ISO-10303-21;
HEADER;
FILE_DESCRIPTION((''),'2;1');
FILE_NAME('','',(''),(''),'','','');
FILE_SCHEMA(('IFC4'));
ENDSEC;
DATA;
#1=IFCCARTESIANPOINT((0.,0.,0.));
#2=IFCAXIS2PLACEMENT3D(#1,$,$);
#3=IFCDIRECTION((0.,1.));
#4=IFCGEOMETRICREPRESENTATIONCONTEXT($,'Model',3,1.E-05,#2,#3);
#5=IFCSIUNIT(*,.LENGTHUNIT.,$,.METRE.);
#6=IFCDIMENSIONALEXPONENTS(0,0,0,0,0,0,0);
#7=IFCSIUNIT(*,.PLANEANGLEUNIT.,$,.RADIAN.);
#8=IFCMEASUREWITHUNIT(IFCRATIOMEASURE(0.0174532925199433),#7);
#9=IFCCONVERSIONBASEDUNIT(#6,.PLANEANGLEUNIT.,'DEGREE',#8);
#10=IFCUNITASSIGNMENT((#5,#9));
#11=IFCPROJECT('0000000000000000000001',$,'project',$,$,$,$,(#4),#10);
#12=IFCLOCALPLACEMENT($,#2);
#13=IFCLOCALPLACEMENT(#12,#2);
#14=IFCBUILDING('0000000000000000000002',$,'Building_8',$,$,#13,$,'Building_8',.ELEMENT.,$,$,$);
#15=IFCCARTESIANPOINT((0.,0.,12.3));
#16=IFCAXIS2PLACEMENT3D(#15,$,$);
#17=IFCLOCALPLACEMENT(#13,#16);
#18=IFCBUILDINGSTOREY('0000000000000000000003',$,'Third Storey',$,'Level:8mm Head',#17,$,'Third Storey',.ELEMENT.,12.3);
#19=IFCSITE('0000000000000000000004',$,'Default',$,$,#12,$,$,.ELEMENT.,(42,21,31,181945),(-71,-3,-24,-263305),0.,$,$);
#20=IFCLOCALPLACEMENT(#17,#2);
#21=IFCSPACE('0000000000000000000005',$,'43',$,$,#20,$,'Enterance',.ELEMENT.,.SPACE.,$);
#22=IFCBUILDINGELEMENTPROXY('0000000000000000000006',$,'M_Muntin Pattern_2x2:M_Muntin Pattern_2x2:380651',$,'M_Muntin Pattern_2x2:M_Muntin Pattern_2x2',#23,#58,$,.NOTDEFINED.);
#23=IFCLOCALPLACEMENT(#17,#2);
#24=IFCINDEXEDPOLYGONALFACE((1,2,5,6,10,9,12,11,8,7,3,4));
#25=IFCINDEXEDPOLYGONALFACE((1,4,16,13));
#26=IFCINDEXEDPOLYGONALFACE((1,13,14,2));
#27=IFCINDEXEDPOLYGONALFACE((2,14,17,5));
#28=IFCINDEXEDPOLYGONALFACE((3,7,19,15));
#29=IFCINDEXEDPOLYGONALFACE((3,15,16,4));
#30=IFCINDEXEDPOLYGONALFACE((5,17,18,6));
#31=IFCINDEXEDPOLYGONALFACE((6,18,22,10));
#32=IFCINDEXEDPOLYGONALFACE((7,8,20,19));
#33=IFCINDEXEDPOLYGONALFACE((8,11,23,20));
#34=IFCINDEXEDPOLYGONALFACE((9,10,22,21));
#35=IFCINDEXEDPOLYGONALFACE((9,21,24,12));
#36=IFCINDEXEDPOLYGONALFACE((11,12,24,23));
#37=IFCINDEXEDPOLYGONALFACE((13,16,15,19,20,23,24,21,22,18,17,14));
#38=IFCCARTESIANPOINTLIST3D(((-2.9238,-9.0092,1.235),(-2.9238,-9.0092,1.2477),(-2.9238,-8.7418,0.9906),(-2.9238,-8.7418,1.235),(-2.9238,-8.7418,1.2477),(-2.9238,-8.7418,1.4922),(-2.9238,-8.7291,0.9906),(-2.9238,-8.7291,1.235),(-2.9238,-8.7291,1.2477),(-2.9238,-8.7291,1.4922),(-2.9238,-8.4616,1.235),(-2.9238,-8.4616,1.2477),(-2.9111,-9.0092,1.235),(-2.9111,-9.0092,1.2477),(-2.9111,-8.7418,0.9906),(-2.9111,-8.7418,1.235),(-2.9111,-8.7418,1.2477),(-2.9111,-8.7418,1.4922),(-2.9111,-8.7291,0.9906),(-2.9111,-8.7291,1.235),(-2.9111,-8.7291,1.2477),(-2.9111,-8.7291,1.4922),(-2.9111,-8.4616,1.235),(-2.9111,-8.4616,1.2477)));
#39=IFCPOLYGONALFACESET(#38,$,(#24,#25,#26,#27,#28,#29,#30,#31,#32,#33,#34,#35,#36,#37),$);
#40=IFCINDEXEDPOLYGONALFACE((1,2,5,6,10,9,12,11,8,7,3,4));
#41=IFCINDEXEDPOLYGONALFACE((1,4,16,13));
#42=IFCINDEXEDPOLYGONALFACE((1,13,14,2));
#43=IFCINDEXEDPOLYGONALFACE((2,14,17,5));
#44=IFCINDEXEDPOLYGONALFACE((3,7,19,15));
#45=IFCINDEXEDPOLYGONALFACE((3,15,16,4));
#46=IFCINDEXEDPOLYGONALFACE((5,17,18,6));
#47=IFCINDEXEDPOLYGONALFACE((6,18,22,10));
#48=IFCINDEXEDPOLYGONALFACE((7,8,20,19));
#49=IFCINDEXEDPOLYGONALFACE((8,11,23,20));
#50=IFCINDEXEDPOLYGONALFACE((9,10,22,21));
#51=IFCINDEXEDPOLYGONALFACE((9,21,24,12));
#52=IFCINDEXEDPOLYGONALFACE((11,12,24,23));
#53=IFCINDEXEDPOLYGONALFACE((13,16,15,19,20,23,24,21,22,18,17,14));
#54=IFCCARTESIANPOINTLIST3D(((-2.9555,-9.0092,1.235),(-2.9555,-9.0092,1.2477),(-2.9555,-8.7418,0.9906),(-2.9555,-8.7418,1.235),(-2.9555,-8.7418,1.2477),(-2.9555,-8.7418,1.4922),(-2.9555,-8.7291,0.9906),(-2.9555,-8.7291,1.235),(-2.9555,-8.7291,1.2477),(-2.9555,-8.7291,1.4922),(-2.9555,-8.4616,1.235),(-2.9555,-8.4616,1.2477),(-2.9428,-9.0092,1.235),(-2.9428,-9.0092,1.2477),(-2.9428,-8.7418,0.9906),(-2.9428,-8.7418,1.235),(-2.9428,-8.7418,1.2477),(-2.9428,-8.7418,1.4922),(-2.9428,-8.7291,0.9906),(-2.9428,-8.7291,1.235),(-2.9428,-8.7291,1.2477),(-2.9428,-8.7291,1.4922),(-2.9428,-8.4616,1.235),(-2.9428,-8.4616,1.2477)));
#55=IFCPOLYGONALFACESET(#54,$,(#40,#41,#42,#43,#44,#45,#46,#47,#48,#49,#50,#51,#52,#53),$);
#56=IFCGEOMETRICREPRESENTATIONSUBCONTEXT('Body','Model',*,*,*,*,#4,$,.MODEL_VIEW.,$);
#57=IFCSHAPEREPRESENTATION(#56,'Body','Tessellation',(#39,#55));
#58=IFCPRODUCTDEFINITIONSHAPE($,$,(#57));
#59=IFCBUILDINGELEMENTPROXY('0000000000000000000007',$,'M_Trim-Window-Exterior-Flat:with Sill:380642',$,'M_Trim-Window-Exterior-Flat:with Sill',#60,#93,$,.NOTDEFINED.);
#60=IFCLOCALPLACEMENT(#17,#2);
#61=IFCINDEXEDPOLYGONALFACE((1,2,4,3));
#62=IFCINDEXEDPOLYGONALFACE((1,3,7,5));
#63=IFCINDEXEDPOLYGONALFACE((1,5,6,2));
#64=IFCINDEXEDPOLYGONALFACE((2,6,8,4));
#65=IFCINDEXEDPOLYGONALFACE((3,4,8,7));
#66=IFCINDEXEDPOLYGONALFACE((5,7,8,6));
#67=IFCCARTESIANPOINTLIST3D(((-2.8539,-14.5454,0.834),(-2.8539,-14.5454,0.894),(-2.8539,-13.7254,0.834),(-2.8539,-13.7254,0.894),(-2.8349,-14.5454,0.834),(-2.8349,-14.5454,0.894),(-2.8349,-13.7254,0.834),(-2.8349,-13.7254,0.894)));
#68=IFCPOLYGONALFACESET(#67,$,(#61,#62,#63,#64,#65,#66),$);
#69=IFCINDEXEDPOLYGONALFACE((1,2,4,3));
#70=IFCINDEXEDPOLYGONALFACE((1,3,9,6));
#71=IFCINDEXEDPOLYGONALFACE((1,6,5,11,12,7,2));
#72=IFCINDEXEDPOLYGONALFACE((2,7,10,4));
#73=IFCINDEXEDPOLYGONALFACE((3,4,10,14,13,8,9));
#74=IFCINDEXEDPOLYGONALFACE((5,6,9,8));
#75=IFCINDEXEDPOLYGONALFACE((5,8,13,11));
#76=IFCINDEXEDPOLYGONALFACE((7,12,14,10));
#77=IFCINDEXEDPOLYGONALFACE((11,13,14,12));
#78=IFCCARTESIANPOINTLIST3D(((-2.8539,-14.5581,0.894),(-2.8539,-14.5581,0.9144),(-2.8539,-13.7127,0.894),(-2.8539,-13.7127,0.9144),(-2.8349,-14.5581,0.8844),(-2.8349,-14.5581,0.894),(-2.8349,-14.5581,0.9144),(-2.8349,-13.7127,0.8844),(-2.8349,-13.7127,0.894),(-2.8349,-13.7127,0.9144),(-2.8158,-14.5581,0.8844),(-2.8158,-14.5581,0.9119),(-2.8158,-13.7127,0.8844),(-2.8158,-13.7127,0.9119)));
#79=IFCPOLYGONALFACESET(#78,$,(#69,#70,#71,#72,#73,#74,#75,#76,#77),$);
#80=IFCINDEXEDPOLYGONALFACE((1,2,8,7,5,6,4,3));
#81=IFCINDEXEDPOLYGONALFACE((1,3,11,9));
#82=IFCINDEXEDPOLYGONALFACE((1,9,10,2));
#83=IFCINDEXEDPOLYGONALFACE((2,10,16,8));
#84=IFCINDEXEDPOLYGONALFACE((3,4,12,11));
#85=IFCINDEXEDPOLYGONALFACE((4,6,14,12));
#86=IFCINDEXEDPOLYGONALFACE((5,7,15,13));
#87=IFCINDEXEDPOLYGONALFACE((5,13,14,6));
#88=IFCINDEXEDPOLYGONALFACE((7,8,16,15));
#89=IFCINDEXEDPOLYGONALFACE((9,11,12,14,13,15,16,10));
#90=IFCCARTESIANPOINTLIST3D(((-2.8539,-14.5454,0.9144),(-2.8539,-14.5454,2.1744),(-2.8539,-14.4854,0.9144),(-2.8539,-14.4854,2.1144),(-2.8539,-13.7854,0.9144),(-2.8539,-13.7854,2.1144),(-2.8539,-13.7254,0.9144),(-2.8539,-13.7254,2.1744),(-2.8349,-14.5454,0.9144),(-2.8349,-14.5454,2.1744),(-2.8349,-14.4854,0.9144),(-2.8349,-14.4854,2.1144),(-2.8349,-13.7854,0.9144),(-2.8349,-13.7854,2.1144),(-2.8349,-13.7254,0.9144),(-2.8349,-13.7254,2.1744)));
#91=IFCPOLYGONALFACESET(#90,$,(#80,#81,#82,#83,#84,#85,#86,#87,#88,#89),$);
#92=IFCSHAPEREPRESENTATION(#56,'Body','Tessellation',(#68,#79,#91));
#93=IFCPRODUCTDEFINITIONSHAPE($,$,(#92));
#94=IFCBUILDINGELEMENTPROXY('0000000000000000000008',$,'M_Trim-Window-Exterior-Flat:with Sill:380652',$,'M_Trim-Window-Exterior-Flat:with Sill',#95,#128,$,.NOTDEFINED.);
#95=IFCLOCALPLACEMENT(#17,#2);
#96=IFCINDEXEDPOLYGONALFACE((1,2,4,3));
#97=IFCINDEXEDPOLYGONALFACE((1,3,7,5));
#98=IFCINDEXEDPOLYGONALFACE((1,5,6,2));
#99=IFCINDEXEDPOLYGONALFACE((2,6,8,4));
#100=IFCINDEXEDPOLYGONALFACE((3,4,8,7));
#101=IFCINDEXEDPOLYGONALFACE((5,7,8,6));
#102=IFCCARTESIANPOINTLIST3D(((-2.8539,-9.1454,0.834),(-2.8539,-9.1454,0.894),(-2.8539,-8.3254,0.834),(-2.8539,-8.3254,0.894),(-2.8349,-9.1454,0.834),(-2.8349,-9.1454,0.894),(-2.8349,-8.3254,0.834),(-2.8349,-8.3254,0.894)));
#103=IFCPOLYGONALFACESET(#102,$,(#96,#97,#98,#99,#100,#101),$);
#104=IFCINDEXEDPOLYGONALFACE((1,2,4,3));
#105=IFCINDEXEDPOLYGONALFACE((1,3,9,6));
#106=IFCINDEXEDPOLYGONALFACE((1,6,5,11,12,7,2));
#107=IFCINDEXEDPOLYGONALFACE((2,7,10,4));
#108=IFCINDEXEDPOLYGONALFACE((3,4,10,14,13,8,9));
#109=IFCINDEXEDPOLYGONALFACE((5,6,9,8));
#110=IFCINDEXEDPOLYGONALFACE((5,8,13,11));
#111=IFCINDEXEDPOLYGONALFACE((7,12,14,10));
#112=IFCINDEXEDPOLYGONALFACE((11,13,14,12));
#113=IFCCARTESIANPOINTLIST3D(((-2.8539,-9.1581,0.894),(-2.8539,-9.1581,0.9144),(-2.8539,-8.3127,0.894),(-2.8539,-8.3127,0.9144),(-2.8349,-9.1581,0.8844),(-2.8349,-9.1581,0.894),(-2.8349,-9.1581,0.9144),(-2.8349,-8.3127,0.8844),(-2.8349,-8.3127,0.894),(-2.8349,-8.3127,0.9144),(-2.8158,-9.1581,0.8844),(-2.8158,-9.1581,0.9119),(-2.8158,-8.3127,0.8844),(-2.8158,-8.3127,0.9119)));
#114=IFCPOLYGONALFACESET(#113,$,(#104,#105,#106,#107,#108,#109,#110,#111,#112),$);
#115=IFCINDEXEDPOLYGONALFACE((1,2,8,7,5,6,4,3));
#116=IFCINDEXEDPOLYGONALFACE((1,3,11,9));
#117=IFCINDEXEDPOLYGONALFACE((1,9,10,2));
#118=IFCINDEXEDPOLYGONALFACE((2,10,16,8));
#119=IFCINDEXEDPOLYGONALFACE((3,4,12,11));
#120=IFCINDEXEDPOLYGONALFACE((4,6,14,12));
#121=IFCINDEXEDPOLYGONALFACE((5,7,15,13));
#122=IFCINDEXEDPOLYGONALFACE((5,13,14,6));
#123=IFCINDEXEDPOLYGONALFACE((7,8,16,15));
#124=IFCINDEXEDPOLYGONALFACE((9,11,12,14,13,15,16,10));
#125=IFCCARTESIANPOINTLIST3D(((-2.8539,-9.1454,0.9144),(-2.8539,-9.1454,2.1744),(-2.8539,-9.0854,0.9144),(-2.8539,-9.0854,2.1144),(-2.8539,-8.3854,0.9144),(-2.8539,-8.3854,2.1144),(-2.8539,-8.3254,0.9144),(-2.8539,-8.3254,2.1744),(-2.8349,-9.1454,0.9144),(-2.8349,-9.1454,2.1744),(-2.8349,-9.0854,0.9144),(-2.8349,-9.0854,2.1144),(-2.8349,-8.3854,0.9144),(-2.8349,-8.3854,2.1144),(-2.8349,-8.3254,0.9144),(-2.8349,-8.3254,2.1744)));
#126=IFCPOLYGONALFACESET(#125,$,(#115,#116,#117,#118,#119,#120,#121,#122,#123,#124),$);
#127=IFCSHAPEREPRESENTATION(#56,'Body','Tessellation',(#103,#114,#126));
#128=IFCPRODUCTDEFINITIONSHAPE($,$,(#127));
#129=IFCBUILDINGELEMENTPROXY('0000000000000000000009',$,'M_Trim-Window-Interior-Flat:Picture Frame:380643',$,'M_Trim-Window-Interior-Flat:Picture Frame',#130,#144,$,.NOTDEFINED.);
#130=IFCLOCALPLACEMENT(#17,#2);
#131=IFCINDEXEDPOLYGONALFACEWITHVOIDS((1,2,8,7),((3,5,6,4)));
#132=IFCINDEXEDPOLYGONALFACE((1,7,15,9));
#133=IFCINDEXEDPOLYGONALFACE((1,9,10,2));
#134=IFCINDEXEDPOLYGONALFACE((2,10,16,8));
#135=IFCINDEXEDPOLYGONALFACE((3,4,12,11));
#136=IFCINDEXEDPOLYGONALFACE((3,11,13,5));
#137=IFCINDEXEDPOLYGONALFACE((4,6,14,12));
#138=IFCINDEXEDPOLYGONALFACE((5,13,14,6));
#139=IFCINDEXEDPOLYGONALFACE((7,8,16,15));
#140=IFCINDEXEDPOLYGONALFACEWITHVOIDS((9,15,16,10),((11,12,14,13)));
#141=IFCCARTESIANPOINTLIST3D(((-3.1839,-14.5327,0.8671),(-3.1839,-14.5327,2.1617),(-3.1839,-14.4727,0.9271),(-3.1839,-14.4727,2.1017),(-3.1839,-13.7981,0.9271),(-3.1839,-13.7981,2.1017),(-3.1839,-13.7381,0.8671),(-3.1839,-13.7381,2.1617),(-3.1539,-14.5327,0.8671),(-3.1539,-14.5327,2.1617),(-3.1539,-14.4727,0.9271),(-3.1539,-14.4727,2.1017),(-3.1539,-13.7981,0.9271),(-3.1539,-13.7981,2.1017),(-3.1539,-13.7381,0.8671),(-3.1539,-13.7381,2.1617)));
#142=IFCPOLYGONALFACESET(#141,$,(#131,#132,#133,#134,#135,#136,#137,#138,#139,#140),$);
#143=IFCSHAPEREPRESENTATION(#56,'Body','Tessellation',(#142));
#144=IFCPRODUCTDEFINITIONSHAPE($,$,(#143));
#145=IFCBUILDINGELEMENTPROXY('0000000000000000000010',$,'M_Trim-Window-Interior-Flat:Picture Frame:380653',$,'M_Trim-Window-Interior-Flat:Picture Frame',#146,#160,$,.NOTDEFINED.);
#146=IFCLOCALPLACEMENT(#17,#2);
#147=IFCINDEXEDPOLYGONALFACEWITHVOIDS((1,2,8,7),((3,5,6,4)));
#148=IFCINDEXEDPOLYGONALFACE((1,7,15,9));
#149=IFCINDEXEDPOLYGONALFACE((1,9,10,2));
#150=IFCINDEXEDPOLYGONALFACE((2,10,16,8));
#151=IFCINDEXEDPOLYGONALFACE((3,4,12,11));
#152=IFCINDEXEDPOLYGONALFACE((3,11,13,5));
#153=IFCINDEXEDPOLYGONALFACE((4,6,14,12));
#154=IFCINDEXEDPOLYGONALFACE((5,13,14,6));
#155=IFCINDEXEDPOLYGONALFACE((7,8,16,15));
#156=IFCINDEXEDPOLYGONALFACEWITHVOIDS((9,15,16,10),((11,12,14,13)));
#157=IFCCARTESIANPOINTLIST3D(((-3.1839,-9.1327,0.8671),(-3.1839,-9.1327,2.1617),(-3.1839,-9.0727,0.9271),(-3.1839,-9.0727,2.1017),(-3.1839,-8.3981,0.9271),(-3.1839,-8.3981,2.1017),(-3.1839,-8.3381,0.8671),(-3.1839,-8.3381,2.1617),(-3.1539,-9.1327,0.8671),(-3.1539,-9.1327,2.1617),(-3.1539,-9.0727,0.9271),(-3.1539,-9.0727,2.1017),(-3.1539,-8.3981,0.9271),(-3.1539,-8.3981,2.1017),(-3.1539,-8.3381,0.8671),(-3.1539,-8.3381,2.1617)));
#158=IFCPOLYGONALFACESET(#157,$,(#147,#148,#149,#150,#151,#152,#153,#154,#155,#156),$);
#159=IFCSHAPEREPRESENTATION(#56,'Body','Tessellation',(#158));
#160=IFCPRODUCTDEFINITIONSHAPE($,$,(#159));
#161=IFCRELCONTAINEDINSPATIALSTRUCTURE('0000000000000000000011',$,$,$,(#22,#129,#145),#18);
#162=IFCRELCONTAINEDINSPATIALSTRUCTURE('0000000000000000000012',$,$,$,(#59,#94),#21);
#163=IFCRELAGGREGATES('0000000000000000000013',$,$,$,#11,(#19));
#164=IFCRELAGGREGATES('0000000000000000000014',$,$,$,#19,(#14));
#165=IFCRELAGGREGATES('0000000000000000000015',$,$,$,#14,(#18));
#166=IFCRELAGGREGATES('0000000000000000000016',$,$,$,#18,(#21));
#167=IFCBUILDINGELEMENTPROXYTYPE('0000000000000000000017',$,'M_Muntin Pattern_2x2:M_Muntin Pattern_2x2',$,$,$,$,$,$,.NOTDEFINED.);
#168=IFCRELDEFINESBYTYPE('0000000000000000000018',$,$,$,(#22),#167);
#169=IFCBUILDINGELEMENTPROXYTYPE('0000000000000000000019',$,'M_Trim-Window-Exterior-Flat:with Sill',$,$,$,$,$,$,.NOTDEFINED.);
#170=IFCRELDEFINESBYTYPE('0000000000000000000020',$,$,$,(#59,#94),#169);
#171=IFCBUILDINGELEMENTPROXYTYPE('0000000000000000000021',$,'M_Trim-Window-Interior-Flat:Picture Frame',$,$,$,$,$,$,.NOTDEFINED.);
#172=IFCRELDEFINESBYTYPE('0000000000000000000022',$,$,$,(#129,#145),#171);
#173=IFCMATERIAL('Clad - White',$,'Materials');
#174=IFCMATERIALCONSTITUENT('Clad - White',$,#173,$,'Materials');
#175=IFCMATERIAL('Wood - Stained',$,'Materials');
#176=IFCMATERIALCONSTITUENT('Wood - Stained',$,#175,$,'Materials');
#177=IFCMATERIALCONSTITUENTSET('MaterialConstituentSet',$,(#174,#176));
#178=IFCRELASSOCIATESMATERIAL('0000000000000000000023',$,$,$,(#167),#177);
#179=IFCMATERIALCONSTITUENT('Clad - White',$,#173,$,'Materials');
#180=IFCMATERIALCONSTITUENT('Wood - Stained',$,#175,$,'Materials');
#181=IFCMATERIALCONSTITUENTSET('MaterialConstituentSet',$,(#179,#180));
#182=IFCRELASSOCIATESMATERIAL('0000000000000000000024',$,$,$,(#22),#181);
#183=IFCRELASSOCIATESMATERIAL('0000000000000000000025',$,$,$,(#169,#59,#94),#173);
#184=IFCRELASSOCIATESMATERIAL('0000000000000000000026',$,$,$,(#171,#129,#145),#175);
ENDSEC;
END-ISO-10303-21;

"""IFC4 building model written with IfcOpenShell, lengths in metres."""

from ifc_helpers import new_model, entity, si_unit, converted_unit, direction, frame, origin, place, context, subcontext, project, spatial, indexed_curve, outline, extrude, source, transform, mapped, material, constituent, constituent_set, type_object, type_shapes, element, save


model = new_model("IFC4")

# Units and contexts
model_context = context("Model", 3, precision=1e-05, world=origin(), true_north=direction((0.0, 1.0)))
body_context = subcontext(model_context, "Body", "Model", "MODEL_VIEW")
ifc_project = project(units=[si_unit("LENGTHUNIT", "METRE"), converted_unit("PLANEANGLEUNIT", "DEGREE", entity("IfcRatioMeasure", 0.0174532925199433), si_unit("PLANEANGLEUNIT", "RADIAN"), dimensions=[0, 0, 0, 0, 0, 0, 0])], contexts=[model_context])

# Site, building, storey
site_placement = place(None, origin())
site = spatial("IfcSite", under=ifc_project, at=site_placement, Name="Default", CompositionType="ELEMENT", RefLatitude=(42, 21, 31, 181945), RefLongitude=(-71, -3, -24, -263305), RefElevation=0.0)
building_placement = place(site_placement, origin())
building = spatial("IfcBuilding", under=site, at=building_placement, Name="Building_8", LongName="Building_8", CompositionType="ELEMENT")
storey_placement = place(building_placement, frame((0.0, 0.0, 12.3)))
storey = spatial("IfcBuildingStorey", under=building, at=storey_placement, Name="Third Storey", ObjectType="Level:8mm Head", LongName="Third Storey", CompositionType="ELEMENT", Elevation=12.3)

# Building element proxy
ifc_material_1 = material(Name="Clad - White", Category="Materials")
ifc_material_2 = material(Name="Wood - Stained", Category="Materials")
ifc_constituent_1 = constituent(ifc_material_1, Name="Clad - White", Category="Materials")
ifc_constituent_2 = constituent(ifc_material_2, Name="Wood - Stained", Category="Materials")
ifc_constituent_set_1 = constituent_set(constituents=[ifc_constituent_1, ifc_constituent_2], Name="MaterialConstituentSet")
building_element_proxy_type_1 = type_object("IfcBuildingElementProxyType", Name="M_Muntin Pattern_2x2:M_Muntin Pattern_2x2", PredefinedType="NOTDEFINED", material=ifc_constituent_set_1)
shared_shape_1 = source(origin(), body_context, "Body", "SweptSolid", [
    extrude(outline(indexed_curve([(0.0064, -0.0064), (0.2508, -0.0064), (0.2508, 0.0063), (0.0064, 0.0063), (0.0064, 0.2738), (-0.0063, 0.2738), (-0.0063, 0.0063), (-0.2508, 0.0063), (-0.2508, -0.0064), (-0.0063, -0.0064), (-0.0063, -0.2738), (0.0064, -0.2738), (0.0064, -0.0064)], self_intersect=False)), frame((0.0, 0.0095, 0.2508), z_axis=(0.0, 1.0, 0.0), x_axis=(0.0, 0.0, 1.0)), (0.0, 0.0, 1.0), 0.0127),
    extrude(outline(indexed_curve([(0.0064, -0.0064), (0.2508, -0.0064), (0.2508, 0.0063), (0.0064, 0.0063), (0.0064, 0.2738), (-0.0063, 0.2738), (-0.0063, 0.0063), (-0.2508, 0.0063), (-0.2508, -0.0064), (-0.0063, -0.0064), (-0.0063, -0.2738), (0.0064, -0.2738), (0.0064, -0.0064)], self_intersect=False)), frame((0.0, -0.0222, 0.2508), z_axis=(0.0, 1.0, 0.0), x_axis=(0.0, 0.0, 1.0)), (0.0, 0.0, 1.0), 0.0127),
])
type_shapes(building_element_proxy_type_1, [shared_shape_1])
ifc_constituent_3 = constituent(ifc_material_1, Name="Clad - White", Category="Materials")
ifc_constituent_4 = constituent(ifc_material_2, Name="Wood - Stained", Category="Materials")
ifc_constituent_set_2 = constituent_set(constituents=[ifc_constituent_3, ifc_constituent_4], Name="MaterialConstituentSet")
proxy_1_placement = place(storey_placement, frame((-2.9333, -8.7354, 0.9906), z_axis=(0.0, 0.0, 1.0), x_axis=(0.0, -1.0, 0.0)))
element("IfcBuildingElementProxy", 1, at=proxy_1_placement, inside=storey, type_object=building_element_proxy_type_1, material=ifc_constituent_set_2, Name="M_Muntin Pattern_2x2:M_Muntin Pattern_2x2:380651", ObjectType="M_Muntin Pattern_2x2:M_Muntin Pattern_2x2", PredefinedType="NOTDEFINED", context=body_context, shape_type="MappedRepresentation", body=[
    mapped(shared_shape_1, transform((0.0, 0.0, 0.0), scale=1.0)),
])

# Shared definitions
space_1_placement = place(storey_placement, origin())
space_1 = spatial("IfcSpace", under=storey, at=space_1_placement, Name="43", LongName="Enterance", CompositionType="ELEMENT", PredefinedType="SPACE")

# Building element proxies
building_element_proxy_type_2 = type_object("IfcBuildingElementProxyType", Name="M_Trim-Window-Exterior-Flat:with Sill", PredefinedType="NOTDEFINED", material=ifc_material_1)
shared_shape_2 = source(origin(), body_context, "Body", "SweptSolid", [
    extrude(outline(indexed_curve([(-0.41, -0.03), (0.41, -0.03), (0.41, 0.03), (-0.41, 0.03), (-0.41, -0.03)], self_intersect=False)), frame((0.0, -1.2504, 0.0), z_axis=(0.0, 0.0, 1.0), x_axis=(-1.0, 0.0, 0.0)), (0.0, 0.0, 1.0), 0.0191),
    extrude(outline(indexed_curve([(-0.019, -0.0152), (0.0, -0.0152), (0.0, -0.0057), (0.019, -0.0057), (0.019, 0.0148), (0.0, 0.0148), (-0.019, 0.0123), (-0.019, -0.0152)], self_intersect=False)), frame((-0.4227, -1.2148, 0.019), z_axis=(1.0, 0.0, 0.0), x_axis=(0.0, 0.0, -1.0)), (0.0, 0.0, 1.0), 0.8454),
    extrude(outline(indexed_curve([(-0.645, -0.41), (0.615, -0.41), (0.615, -0.35), (-0.585, -0.35), (-0.585, 0.35), (0.615, 0.35), (0.615, 0.41), (-0.645, 0.41), (-0.645, -0.41)], self_intersect=False)), frame((0.0, -0.585, 0.0), z_axis=(0.0, 0.0, 1.0), x_axis=(0.0, -1.0, 0.0)), (0.0, 0.0, 1.0), 0.0191),
])
type_shapes(building_element_proxy_type_2, [shared_shape_2])
for number, where, z_axis, x_axis, name in (
    (2, (-2.8539, -14.1354, 2.1144), (1.0, 0.0, 0.0), (0.0, 1.0, 0.0), "M_Trim-Window-Exterior-Flat:with Sill:380642"),
    (3, (-2.8539, -8.7354, 2.1144), (1.0, 0.0, 0.0), (0.0, 1.0, 0.0), "M_Trim-Window-Exterior-Flat:with Sill:380652"),
):
    element("IfcBuildingElementProxy", number, at=place(space_1_placement, frame(where, z_axis=z_axis, x_axis=x_axis)), inside=space_1, type_object=building_element_proxy_type_2, material=ifc_material_1, Name=name, ObjectType="M_Trim-Window-Exterior-Flat:with Sill", PredefinedType="NOTDEFINED", context=body_context, shape_type="MappedRepresentation", body=[
        mapped(shared_shape_2, transform((0.0, 0.0, 0.0), scale=1.0)),
    ])
building_element_proxy_type_3 = type_object("IfcBuildingElementProxyType", Name="M_Trim-Window-Interior-Flat:Picture Frame", PredefinedType="NOTDEFINED", material=ifc_material_2)
shared_shape_3 = source(origin(), body_context, "Body", "SweptSolid", [
    extrude(outline(indexed_curve([(-0.3973, -0.6473), (0.3973, -0.6473), (0.3973, 0.6473), (-0.3973, 0.6473), (-0.3973, -0.6473)], self_intersect=False), holes=[indexed_curve([(-0.3373, -0.5873), (-0.3373, 0.5873), (0.3373, 0.5873), (0.3373, -0.5873), (-0.3373, -0.5873)], self_intersect=False)]), frame((0.0, -0.6, 0.0), z_axis=(0.0, 0.0, 1.0), x_axis=(-1.0, 0.0, 0.0)), (0.0, 0.0, 1.0), 0.03),
])
type_shapes(building_element_proxy_type_3, [shared_shape_3])
for number, where, z_axis, x_axis, name in (
    (4, (-3.1539, -14.1354, 2.1144), (-1.0, 0.0, 0.0), (0.0, -1.0, 0.0), "M_Trim-Window-Interior-Flat:Picture Frame:380643"),
    (5, (-3.1539, -8.7354, 2.1144), (-1.0, 0.0, 0.0), (0.0, -1.0, 0.0), "M_Trim-Window-Interior-Flat:Picture Frame:380653"),
):
    element("IfcBuildingElementProxy", number, at=place(storey_placement, frame(where, z_axis=z_axis, x_axis=x_axis)), inside=storey, type_object=building_element_proxy_type_3, material=ifc_material_2, Name=name, ObjectType="M_Trim-Window-Interior-Flat:Picture Frame", PredefinedType="NOTDEFINED", context=body_context, shape_type="MappedRepresentation", body=[
        mapped(shared_shape_3, transform((0.0, 0.0, 0.0), scale=1.0)),
    ])

save(model, "model.ifc")
